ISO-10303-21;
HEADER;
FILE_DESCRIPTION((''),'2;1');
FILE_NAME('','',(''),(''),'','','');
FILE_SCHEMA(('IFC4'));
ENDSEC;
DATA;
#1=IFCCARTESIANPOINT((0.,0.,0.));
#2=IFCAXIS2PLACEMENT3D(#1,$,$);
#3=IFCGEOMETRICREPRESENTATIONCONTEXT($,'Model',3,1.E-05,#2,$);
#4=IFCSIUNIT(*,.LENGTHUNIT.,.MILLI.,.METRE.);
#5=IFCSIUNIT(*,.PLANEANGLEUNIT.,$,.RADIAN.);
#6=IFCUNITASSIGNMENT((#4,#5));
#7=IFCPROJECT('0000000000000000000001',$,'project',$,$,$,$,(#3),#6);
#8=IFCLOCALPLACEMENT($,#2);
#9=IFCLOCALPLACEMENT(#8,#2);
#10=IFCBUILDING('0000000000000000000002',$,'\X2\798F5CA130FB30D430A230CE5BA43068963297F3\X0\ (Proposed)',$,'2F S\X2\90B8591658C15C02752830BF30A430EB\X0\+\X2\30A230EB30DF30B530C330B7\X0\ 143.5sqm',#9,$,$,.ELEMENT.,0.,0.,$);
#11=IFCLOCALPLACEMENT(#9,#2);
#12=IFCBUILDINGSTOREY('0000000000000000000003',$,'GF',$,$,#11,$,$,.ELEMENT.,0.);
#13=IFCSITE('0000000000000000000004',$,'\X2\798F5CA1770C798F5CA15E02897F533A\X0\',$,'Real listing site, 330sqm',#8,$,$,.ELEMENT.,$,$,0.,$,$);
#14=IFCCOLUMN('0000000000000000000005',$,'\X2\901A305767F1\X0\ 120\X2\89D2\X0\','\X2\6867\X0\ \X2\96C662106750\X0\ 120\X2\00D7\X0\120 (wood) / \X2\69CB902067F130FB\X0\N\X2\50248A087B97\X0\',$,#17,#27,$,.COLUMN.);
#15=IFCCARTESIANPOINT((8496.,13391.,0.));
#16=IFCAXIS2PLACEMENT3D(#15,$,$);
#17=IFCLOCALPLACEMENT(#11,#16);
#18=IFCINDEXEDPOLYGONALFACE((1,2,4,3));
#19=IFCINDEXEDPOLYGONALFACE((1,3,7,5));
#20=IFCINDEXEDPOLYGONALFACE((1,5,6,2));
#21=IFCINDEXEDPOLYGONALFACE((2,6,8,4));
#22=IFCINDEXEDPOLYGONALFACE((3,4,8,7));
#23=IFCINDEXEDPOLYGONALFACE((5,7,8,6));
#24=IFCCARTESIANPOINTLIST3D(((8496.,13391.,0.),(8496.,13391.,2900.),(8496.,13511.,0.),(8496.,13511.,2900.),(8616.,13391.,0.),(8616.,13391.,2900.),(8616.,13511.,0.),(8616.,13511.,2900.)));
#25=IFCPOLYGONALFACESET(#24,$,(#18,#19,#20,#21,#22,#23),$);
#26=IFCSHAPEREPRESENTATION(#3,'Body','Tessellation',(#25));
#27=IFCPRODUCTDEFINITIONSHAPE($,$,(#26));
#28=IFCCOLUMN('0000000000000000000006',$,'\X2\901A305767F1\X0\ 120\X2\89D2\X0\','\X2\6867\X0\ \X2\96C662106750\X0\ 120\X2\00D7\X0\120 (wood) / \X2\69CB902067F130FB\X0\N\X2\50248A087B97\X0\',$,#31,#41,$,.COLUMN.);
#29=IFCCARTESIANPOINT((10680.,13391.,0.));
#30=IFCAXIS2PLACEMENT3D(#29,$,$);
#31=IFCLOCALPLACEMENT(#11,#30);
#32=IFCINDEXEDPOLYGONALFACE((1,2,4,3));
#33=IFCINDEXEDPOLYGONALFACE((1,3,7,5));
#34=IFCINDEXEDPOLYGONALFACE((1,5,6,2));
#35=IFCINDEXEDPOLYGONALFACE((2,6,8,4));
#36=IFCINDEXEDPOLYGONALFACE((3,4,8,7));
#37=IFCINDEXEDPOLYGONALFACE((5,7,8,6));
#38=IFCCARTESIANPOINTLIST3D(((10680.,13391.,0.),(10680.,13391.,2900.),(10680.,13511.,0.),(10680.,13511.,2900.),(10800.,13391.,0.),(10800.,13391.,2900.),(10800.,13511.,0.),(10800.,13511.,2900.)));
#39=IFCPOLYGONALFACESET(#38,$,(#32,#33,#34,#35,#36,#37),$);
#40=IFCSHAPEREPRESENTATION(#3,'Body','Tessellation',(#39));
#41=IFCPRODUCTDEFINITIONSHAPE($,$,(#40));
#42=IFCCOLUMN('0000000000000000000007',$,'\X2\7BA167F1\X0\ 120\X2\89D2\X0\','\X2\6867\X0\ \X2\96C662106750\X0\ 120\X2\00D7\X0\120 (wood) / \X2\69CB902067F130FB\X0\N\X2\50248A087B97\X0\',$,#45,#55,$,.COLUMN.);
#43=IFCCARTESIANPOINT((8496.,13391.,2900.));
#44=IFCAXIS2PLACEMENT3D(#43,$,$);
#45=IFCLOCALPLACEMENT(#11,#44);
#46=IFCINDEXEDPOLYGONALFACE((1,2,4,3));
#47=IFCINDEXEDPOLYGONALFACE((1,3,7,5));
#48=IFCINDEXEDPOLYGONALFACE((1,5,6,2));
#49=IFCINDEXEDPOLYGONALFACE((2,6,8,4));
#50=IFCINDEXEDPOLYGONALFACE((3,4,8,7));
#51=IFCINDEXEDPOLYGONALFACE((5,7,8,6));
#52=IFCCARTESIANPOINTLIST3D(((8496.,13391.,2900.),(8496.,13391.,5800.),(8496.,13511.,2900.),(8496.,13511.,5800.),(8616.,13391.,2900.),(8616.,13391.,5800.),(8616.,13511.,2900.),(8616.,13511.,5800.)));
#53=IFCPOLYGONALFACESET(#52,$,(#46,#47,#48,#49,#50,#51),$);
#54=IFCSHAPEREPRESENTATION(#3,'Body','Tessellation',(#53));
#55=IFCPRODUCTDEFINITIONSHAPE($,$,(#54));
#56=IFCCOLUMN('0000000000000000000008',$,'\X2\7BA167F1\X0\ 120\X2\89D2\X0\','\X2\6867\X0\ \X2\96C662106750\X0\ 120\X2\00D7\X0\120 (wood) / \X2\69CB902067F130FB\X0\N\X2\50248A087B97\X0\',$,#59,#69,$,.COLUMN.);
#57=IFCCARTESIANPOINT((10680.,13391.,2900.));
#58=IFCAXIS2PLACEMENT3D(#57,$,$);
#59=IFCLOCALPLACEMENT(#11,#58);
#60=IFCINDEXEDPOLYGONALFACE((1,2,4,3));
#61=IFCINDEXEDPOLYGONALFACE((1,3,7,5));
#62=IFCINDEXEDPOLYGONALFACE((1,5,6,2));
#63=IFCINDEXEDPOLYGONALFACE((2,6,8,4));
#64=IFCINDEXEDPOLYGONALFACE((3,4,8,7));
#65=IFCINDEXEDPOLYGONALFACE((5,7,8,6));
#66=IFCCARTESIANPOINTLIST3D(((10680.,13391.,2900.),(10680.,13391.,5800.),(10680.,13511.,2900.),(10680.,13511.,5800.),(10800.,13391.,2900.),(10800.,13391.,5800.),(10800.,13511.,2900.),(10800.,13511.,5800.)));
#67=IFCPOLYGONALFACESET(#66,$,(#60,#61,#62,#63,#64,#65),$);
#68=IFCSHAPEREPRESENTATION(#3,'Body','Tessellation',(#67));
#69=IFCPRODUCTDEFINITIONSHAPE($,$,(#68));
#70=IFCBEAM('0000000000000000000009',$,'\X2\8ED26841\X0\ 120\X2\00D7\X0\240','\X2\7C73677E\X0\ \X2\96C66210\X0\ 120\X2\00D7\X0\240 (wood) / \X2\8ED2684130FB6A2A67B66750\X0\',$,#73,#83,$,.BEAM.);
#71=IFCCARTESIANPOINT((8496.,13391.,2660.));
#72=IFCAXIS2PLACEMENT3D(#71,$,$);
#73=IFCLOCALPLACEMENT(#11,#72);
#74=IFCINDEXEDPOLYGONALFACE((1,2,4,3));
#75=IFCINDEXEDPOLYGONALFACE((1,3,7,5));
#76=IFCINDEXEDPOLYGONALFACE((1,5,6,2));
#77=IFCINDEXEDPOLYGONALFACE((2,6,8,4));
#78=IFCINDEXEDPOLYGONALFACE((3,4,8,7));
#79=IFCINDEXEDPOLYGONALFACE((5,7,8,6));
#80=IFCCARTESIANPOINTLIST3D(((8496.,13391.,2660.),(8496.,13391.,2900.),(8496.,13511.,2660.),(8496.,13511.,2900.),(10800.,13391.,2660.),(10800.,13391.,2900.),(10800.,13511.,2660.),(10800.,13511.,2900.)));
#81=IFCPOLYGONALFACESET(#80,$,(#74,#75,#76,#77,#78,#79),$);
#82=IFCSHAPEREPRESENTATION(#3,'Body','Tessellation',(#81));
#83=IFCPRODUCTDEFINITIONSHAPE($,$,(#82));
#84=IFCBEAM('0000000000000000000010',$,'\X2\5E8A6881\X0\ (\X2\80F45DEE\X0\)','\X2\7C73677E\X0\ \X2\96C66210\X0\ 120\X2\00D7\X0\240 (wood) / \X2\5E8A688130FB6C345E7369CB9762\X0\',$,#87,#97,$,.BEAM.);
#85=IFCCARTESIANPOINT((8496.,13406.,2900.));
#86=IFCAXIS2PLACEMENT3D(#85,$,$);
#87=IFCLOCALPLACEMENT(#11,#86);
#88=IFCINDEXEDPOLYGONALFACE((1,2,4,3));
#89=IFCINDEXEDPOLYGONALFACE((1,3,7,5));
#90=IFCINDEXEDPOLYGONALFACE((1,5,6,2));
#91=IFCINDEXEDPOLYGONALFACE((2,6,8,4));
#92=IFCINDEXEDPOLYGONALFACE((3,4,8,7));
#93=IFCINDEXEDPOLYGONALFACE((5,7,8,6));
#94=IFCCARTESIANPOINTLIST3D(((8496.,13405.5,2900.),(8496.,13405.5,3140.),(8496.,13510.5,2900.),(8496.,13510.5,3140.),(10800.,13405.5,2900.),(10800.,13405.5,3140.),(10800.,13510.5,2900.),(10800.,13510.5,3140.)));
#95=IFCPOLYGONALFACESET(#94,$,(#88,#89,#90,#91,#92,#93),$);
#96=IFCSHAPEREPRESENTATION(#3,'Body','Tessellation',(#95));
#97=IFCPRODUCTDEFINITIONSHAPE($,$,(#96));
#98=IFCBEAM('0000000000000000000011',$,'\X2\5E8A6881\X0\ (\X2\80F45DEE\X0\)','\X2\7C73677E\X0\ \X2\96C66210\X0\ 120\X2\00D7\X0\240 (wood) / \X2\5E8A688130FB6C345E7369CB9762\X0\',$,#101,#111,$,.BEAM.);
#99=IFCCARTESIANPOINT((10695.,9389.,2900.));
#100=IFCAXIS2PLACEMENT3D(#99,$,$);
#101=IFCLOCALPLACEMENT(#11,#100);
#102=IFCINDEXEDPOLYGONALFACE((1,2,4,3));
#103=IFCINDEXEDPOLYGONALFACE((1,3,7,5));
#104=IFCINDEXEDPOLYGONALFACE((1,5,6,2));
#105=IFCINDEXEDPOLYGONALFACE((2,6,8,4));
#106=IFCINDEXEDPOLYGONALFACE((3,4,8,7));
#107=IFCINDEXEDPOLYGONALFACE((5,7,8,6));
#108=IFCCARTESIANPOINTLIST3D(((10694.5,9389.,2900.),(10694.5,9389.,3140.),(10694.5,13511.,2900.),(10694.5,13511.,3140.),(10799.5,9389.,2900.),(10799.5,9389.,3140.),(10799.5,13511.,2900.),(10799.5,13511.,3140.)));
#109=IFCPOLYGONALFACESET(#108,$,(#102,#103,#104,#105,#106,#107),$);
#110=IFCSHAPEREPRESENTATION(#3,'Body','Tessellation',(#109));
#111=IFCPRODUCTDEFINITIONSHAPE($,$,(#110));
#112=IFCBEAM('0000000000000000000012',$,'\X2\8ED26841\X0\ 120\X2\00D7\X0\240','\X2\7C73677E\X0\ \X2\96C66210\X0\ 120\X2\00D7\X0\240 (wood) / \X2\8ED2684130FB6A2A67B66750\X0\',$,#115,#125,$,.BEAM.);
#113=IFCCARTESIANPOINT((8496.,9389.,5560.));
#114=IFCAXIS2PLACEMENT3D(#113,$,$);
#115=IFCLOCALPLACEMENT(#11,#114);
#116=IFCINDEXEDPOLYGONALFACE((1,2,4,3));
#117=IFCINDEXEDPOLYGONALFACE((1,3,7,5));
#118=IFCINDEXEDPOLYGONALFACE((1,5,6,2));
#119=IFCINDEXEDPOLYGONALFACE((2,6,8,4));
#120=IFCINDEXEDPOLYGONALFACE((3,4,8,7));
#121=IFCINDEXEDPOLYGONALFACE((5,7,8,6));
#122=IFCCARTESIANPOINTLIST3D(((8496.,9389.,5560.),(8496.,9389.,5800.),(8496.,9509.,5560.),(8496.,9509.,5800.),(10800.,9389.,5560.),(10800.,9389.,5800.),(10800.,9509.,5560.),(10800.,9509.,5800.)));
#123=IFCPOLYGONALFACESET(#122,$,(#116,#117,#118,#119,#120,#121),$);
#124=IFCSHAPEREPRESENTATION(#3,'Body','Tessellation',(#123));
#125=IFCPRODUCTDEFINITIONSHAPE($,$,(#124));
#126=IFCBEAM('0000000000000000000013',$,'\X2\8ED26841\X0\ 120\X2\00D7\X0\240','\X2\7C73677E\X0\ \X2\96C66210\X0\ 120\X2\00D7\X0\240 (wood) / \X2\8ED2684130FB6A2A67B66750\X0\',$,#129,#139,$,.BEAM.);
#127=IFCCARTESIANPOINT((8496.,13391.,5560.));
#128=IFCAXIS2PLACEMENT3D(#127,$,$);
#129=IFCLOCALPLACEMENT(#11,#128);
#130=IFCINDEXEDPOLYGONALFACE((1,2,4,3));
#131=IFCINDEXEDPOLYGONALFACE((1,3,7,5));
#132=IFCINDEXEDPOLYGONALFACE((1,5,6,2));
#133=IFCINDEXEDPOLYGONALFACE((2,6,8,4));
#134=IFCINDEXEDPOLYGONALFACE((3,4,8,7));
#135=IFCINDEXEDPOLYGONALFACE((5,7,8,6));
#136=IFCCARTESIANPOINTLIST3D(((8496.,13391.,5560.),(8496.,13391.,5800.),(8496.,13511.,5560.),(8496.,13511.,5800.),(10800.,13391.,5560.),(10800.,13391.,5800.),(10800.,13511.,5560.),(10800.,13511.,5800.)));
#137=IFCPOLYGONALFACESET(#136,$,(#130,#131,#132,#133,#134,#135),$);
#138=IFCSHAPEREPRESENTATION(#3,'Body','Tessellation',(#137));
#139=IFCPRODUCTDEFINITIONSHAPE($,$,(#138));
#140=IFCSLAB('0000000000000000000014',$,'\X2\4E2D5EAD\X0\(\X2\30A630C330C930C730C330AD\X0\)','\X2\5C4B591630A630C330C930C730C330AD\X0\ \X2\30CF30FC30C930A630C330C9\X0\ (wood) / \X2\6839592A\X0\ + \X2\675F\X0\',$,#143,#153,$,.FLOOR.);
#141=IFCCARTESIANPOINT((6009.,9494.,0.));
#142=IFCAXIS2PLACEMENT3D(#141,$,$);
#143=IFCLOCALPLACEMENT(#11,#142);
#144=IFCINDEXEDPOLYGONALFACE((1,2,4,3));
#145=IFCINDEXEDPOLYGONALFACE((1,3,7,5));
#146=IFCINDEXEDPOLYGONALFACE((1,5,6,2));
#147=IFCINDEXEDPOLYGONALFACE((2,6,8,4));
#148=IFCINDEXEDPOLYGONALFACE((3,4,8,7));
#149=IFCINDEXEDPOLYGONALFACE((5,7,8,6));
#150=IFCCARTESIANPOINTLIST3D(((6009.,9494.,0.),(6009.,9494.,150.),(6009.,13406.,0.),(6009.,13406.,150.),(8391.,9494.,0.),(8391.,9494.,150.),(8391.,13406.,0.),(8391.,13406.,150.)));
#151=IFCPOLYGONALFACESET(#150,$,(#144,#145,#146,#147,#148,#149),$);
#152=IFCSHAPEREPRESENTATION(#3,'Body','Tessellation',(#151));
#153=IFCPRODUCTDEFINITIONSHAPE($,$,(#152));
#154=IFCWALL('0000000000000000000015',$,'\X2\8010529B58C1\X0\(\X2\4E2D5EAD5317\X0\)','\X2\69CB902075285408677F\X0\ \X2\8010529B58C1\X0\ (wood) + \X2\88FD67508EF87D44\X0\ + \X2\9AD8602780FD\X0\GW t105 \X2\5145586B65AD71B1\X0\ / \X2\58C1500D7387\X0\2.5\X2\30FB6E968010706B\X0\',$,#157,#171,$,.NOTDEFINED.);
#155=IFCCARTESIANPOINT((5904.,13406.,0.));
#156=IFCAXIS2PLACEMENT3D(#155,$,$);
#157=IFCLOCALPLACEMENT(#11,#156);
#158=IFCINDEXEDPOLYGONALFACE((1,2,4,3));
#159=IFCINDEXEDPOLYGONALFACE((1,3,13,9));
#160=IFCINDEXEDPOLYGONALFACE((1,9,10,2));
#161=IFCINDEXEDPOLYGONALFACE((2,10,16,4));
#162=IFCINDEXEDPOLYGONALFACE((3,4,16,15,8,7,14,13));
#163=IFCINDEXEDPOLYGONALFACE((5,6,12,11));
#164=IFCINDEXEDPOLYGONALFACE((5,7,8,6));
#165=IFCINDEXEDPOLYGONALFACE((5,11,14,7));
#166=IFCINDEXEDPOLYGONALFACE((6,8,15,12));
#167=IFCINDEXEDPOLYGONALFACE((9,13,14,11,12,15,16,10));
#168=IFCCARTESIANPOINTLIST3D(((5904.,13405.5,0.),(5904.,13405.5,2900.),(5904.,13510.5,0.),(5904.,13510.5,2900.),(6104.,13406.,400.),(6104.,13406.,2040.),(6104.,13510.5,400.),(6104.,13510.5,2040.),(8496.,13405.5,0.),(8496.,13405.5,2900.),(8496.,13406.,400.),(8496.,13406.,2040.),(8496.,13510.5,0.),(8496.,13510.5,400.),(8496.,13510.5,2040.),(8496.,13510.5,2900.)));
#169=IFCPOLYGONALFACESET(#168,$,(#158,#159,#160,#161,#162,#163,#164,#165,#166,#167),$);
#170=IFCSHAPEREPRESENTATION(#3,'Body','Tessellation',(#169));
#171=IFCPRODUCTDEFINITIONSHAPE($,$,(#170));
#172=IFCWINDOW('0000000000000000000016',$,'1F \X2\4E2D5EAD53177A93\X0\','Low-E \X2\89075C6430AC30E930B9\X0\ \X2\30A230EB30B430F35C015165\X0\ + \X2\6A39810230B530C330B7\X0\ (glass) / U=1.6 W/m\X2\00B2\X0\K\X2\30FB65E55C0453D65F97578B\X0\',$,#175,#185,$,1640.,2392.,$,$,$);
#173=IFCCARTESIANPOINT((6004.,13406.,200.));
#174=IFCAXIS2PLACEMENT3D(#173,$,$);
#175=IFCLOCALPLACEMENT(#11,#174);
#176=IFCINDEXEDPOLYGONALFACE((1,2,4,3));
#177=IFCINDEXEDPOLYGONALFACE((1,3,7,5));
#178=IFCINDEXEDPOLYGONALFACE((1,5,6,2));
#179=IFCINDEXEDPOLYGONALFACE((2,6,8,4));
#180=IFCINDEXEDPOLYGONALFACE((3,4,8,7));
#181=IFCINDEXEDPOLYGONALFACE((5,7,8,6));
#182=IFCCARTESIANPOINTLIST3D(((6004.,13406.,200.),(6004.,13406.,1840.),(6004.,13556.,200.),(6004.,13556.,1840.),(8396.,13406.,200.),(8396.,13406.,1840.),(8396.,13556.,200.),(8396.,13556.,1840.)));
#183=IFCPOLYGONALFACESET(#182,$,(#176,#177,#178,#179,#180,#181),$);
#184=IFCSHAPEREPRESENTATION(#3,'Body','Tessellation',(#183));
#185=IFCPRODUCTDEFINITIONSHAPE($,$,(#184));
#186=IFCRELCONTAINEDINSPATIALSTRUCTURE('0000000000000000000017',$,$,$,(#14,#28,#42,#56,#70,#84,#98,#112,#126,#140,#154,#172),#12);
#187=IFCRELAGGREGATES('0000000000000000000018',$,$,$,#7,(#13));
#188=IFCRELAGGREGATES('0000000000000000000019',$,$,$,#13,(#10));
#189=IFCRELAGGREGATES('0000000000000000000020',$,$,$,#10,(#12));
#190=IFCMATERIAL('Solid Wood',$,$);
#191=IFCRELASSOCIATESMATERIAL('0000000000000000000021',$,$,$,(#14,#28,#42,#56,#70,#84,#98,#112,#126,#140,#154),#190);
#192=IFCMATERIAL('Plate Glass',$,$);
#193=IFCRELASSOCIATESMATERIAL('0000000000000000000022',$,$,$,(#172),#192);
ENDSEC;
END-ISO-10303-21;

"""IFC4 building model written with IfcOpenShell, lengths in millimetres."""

from ifc_helpers import new_model, si_unit, frame, frame_2d, origin, place, context, project, spatial, rectangle, extrude, material, element, fill, save


model = new_model("IFC4")

# Units and contexts
model_context = context("Model", 3, precision=1e-05, world=origin())
ifc_project = project(units=[si_unit("LENGTHUNIT", "METRE", prefix="MILLI"), si_unit("PLANEANGLEUNIT", "RADIAN")], contexts=[model_context])

# Site, building, storey
site_placement = place(None, origin())
site = spatial("IfcSite", under=ifc_project, at=site_placement, Name="福岡県福岡市西区", ObjectType="Real listing site, 330sqm", CompositionType="ELEMENT", RefElevation=0.0)
building_placement = place(site_placement, origin())
building = spatial("IfcBuilding", under=site, at=building_placement, Name="福岡・ピアノ室と防音 (Proposed)", ObjectType="2F S邸外壁専用タイル+アルミサッシ 143.5sqm", CompositionType="ELEMENT", ElevationOfRefHeight=0.0, ElevationOfTerrain=0.0)
storey_placement = place(building_placement, origin())
storey = spatial("IfcBuildingStorey", under=building, at=storey_placement, Name="GF", CompositionType="ELEMENT", Elevation=0.0)

# Columns
ifc_material_1 = material(Name="Solid Wood")
column_1_placement = place(storey_placement, frame((8496.0, 13391.0, 0.0)))
element("IfcColumn", 1, at=column_1_placement, inside=storey, material=ifc_material_1, Name="通し柱 120角", Description="桧 集成材 120×120 (wood) / 構造柱・N値計算", PredefinedType="COLUMN", context=model_context, shape_type="SweptSolid", body=[
    extrude(rectangle(XDim=120.0, YDim=120.0, at=frame_2d((60.0, 60.0))), frame((8496.0, 13391.0, 0.0)), (0.0, 0.0, 1.0), 2900.0),
])
column_2_placement = place(storey_placement, frame((10680.0, 13391.0, 0.0)))
element("IfcColumn", 2, at=column_2_placement, inside=storey, material=ifc_material_1, Name="通し柱 120角", Description="桧 集成材 120×120 (wood) / 構造柱・N値計算", PredefinedType="COLUMN", context=model_context, shape_type="SweptSolid", body=[
    extrude(rectangle(XDim=120.0, YDim=120.0, at=frame_2d((60.0, 60.0))), frame((10680.0, 13391.0, 0.0)), (0.0, 0.0, 1.0), 2900.0),
])
column_3_placement = place(storey_placement, frame((8496.0, 13391.0, 2900.0)))
element("IfcColumn", 3, at=column_3_placement, inside=storey, material=ifc_material_1, Name="管柱 120角", Description="桧 集成材 120×120 (wood) / 構造柱・N値計算", PredefinedType="COLUMN", context=model_context, shape_type="SweptSolid", body=[
    extrude(rectangle(XDim=120.0, YDim=120.0, at=frame_2d((60.0, 60.0))), frame((8496.0, 13391.0, 2900.0)), (0.0, 0.0, 1.0), 2900.0),
])
column_4_placement = place(storey_placement, frame((10680.0, 13391.0, 2900.0)))
element("IfcColumn", 4, at=column_4_placement, inside=storey, material=ifc_material_1, Name="管柱 120角", Description="桧 集成材 120×120 (wood) / 構造柱・N値計算", PredefinedType="COLUMN", context=model_context, shape_type="SweptSolid", body=[
    extrude(rectangle(XDim=120.0, YDim=120.0, at=frame_2d((60.0, 60.0))), frame((10680.0, 13391.0, 2900.0)), (0.0, 0.0, 1.0), 2900.0),
])

# Beams
beam_1_placement = place(storey_placement, frame((8496.0, 13391.0, 2660.0)))
element("IfcBeam", 5, at=beam_1_placement, inside=storey, material=ifc_material_1, Name="軒桁 120×240", Description="米松 集成 120×240 (wood) / 軒桁・横架材", PredefinedType="BEAM", context=model_context, shape_type="SweptSolid", body=[
    extrude(rectangle(XDim=2304.0, YDim=120.0, at=frame_2d((1152.0, 60.0))), frame((8496.0, 13391.0, 2660.0)), (0.0, 0.0, 1.0), 240.0),
])
beam_2_placement = place(storey_placement, frame((8496.0, 13406.0, 2900.0)))
element("IfcBeam", 6, at=beam_2_placement, inside=storey, material=ifc_material_1, Name="床梁 (胴差)", Description="米松 集成 120×240 (wood) / 床梁・水平構面", PredefinedType="BEAM", context=model_context, shape_type="SweptSolid", body=[
    extrude(rectangle(XDim=2304.0, YDim=105.0, at=frame_2d((1152.0, 52.0))), frame((8496.0, 13406.0, 2900.0)), (0.0, 0.0, 1.0), 240.0),
])
beam_3_placement = place(storey_placement, frame((10695.0, 9389.0, 2900.0)))
element("IfcBeam", 7, at=beam_3_placement, inside=storey, material=ifc_material_1, Name="床梁 (胴差)", Description="米松 集成 120×240 (wood) / 床梁・水平構面", PredefinedType="BEAM", context=model_context, shape_type="SweptSolid", body=[
    extrude(rectangle(XDim=105.0, YDim=4122.0, at=frame_2d((52.0, 2061.0))), frame((10695.0, 9389.0, 2900.0)), (0.0, 0.0, 1.0), 240.0),
])
beam_4_placement = place(storey_placement, frame((8496.0, 9389.0, 5560.0)))
element("IfcBeam", 8, at=beam_4_placement, inside=storey, material=ifc_material_1, Name="軒桁 120×240", Description="米松 集成 120×240 (wood) / 軒桁・横架材", PredefinedType="BEAM", context=model_context, shape_type="SweptSolid", body=[
    extrude(rectangle(XDim=2304.0, YDim=120.0, at=frame_2d((1152.0, 60.0))), frame((8496.0, 9389.0, 5560.0)), (0.0, 0.0, 1.0), 240.0),
])
beam_5_placement = place(storey_placement, frame((8496.0, 13391.0, 5560.0)))
element("IfcBeam", 9, at=beam_5_placement, inside=storey, material=ifc_material_1, Name="軒桁 120×240", Description="米松 集成 120×240 (wood) / 軒桁・横架材", PredefinedType="BEAM", context=model_context, shape_type="SweptSolid", body=[
    extrude(rectangle(XDim=2304.0, YDim=120.0, at=frame_2d((1152.0, 60.0))), frame((8496.0, 13391.0, 5560.0)), (0.0, 0.0, 1.0), 240.0),
])

# Slab
slab_placement = place(storey_placement, frame((6009.0, 9494.0, 0.0)))
element("IfcSlab", 10, at=slab_placement, inside=storey, material=ifc_material_1, Name="中庭(ウッドデッキ)", Description="屋外ウッドデッキ ハードウッド (wood) / 根太 + 束", PredefinedType="FLOOR", context=model_context, shape_type="SweptSolid", body=[
    extrude(rectangle(XDim=2382.0, YDim=3912.0, at=frame_2d((1191.0, 1956.0))), frame((6009.0, 9494.0, 0.0)), (0.0, 0.0, 1.0), 150.0),
])

# Wall, opening, window
wall_1_placement = place(storey_placement, frame((5904.0, 13406.0, 0.0)))
wall_1 = element("IfcWall", 11, at=wall_1_placement, inside=storey, material=ifc_material_1, Name="耐力壁(中庭北)", Description="構造用合板 耐力壁 (wood) + 製材軸組 + 高性能GW t105 充填断熱 / 壁倍率2.5・準耐火", PredefinedType="NOTDEFINED", context=model_context, shape_type="SweptSolid", body=[
    extrude(rectangle(XDim=2592.0, YDim=105.0, at=frame_2d((1296.0, 52.0))), frame((5904.0, 13406.0, 0.0)), (0.0, 0.0, 1.0), 2900.0),
])
opening_1_placement = place(storey_placement, frame((6004.0, 13406.0, 200.0)))
opening_1 = element("IfcOpeningElement", 12, at=opening_1_placement, cuts=wall_1, PredefinedType="NOTDEFINED", context=model_context, shape_type="SweptSolid", body=[
    extrude(rectangle(XDim=2392.0, YDim=150.0, at=frame_2d((1196.0, 75.0))), frame((6004.0, 13406.0, 200.0)), (0.0, 0.0, 1.0), 1640.0),
])
ifc_material_2 = material(Name="Plate Glass")
window_1_placement = place(storey_placement, frame((6004.0, 13406.0, 200.0)))
window_1 = element("IfcWindow", 13, at=window_1_placement, inside=storey, material=ifc_material_2, Name="1F 中庭北窓", Description="Low-E 複層ガラス アルゴン封入 + 樹脂サッシ (glass) / U=1.6 W/m²K・日射取得型", OverallHeight=1640.0, OverallWidth=2392.0, context=model_context, shape_type="SweptSolid", body=[
    extrude(rectangle(XDim=2392.0, YDim=150.0, at=frame_2d((1196.0, 75.0))), frame((6004.0, 13406.0, 200.0)), (0.0, 0.0, 1.0), 1640.0),
])
fill(opening_1, window_1)

save(model, "model.ifc")
